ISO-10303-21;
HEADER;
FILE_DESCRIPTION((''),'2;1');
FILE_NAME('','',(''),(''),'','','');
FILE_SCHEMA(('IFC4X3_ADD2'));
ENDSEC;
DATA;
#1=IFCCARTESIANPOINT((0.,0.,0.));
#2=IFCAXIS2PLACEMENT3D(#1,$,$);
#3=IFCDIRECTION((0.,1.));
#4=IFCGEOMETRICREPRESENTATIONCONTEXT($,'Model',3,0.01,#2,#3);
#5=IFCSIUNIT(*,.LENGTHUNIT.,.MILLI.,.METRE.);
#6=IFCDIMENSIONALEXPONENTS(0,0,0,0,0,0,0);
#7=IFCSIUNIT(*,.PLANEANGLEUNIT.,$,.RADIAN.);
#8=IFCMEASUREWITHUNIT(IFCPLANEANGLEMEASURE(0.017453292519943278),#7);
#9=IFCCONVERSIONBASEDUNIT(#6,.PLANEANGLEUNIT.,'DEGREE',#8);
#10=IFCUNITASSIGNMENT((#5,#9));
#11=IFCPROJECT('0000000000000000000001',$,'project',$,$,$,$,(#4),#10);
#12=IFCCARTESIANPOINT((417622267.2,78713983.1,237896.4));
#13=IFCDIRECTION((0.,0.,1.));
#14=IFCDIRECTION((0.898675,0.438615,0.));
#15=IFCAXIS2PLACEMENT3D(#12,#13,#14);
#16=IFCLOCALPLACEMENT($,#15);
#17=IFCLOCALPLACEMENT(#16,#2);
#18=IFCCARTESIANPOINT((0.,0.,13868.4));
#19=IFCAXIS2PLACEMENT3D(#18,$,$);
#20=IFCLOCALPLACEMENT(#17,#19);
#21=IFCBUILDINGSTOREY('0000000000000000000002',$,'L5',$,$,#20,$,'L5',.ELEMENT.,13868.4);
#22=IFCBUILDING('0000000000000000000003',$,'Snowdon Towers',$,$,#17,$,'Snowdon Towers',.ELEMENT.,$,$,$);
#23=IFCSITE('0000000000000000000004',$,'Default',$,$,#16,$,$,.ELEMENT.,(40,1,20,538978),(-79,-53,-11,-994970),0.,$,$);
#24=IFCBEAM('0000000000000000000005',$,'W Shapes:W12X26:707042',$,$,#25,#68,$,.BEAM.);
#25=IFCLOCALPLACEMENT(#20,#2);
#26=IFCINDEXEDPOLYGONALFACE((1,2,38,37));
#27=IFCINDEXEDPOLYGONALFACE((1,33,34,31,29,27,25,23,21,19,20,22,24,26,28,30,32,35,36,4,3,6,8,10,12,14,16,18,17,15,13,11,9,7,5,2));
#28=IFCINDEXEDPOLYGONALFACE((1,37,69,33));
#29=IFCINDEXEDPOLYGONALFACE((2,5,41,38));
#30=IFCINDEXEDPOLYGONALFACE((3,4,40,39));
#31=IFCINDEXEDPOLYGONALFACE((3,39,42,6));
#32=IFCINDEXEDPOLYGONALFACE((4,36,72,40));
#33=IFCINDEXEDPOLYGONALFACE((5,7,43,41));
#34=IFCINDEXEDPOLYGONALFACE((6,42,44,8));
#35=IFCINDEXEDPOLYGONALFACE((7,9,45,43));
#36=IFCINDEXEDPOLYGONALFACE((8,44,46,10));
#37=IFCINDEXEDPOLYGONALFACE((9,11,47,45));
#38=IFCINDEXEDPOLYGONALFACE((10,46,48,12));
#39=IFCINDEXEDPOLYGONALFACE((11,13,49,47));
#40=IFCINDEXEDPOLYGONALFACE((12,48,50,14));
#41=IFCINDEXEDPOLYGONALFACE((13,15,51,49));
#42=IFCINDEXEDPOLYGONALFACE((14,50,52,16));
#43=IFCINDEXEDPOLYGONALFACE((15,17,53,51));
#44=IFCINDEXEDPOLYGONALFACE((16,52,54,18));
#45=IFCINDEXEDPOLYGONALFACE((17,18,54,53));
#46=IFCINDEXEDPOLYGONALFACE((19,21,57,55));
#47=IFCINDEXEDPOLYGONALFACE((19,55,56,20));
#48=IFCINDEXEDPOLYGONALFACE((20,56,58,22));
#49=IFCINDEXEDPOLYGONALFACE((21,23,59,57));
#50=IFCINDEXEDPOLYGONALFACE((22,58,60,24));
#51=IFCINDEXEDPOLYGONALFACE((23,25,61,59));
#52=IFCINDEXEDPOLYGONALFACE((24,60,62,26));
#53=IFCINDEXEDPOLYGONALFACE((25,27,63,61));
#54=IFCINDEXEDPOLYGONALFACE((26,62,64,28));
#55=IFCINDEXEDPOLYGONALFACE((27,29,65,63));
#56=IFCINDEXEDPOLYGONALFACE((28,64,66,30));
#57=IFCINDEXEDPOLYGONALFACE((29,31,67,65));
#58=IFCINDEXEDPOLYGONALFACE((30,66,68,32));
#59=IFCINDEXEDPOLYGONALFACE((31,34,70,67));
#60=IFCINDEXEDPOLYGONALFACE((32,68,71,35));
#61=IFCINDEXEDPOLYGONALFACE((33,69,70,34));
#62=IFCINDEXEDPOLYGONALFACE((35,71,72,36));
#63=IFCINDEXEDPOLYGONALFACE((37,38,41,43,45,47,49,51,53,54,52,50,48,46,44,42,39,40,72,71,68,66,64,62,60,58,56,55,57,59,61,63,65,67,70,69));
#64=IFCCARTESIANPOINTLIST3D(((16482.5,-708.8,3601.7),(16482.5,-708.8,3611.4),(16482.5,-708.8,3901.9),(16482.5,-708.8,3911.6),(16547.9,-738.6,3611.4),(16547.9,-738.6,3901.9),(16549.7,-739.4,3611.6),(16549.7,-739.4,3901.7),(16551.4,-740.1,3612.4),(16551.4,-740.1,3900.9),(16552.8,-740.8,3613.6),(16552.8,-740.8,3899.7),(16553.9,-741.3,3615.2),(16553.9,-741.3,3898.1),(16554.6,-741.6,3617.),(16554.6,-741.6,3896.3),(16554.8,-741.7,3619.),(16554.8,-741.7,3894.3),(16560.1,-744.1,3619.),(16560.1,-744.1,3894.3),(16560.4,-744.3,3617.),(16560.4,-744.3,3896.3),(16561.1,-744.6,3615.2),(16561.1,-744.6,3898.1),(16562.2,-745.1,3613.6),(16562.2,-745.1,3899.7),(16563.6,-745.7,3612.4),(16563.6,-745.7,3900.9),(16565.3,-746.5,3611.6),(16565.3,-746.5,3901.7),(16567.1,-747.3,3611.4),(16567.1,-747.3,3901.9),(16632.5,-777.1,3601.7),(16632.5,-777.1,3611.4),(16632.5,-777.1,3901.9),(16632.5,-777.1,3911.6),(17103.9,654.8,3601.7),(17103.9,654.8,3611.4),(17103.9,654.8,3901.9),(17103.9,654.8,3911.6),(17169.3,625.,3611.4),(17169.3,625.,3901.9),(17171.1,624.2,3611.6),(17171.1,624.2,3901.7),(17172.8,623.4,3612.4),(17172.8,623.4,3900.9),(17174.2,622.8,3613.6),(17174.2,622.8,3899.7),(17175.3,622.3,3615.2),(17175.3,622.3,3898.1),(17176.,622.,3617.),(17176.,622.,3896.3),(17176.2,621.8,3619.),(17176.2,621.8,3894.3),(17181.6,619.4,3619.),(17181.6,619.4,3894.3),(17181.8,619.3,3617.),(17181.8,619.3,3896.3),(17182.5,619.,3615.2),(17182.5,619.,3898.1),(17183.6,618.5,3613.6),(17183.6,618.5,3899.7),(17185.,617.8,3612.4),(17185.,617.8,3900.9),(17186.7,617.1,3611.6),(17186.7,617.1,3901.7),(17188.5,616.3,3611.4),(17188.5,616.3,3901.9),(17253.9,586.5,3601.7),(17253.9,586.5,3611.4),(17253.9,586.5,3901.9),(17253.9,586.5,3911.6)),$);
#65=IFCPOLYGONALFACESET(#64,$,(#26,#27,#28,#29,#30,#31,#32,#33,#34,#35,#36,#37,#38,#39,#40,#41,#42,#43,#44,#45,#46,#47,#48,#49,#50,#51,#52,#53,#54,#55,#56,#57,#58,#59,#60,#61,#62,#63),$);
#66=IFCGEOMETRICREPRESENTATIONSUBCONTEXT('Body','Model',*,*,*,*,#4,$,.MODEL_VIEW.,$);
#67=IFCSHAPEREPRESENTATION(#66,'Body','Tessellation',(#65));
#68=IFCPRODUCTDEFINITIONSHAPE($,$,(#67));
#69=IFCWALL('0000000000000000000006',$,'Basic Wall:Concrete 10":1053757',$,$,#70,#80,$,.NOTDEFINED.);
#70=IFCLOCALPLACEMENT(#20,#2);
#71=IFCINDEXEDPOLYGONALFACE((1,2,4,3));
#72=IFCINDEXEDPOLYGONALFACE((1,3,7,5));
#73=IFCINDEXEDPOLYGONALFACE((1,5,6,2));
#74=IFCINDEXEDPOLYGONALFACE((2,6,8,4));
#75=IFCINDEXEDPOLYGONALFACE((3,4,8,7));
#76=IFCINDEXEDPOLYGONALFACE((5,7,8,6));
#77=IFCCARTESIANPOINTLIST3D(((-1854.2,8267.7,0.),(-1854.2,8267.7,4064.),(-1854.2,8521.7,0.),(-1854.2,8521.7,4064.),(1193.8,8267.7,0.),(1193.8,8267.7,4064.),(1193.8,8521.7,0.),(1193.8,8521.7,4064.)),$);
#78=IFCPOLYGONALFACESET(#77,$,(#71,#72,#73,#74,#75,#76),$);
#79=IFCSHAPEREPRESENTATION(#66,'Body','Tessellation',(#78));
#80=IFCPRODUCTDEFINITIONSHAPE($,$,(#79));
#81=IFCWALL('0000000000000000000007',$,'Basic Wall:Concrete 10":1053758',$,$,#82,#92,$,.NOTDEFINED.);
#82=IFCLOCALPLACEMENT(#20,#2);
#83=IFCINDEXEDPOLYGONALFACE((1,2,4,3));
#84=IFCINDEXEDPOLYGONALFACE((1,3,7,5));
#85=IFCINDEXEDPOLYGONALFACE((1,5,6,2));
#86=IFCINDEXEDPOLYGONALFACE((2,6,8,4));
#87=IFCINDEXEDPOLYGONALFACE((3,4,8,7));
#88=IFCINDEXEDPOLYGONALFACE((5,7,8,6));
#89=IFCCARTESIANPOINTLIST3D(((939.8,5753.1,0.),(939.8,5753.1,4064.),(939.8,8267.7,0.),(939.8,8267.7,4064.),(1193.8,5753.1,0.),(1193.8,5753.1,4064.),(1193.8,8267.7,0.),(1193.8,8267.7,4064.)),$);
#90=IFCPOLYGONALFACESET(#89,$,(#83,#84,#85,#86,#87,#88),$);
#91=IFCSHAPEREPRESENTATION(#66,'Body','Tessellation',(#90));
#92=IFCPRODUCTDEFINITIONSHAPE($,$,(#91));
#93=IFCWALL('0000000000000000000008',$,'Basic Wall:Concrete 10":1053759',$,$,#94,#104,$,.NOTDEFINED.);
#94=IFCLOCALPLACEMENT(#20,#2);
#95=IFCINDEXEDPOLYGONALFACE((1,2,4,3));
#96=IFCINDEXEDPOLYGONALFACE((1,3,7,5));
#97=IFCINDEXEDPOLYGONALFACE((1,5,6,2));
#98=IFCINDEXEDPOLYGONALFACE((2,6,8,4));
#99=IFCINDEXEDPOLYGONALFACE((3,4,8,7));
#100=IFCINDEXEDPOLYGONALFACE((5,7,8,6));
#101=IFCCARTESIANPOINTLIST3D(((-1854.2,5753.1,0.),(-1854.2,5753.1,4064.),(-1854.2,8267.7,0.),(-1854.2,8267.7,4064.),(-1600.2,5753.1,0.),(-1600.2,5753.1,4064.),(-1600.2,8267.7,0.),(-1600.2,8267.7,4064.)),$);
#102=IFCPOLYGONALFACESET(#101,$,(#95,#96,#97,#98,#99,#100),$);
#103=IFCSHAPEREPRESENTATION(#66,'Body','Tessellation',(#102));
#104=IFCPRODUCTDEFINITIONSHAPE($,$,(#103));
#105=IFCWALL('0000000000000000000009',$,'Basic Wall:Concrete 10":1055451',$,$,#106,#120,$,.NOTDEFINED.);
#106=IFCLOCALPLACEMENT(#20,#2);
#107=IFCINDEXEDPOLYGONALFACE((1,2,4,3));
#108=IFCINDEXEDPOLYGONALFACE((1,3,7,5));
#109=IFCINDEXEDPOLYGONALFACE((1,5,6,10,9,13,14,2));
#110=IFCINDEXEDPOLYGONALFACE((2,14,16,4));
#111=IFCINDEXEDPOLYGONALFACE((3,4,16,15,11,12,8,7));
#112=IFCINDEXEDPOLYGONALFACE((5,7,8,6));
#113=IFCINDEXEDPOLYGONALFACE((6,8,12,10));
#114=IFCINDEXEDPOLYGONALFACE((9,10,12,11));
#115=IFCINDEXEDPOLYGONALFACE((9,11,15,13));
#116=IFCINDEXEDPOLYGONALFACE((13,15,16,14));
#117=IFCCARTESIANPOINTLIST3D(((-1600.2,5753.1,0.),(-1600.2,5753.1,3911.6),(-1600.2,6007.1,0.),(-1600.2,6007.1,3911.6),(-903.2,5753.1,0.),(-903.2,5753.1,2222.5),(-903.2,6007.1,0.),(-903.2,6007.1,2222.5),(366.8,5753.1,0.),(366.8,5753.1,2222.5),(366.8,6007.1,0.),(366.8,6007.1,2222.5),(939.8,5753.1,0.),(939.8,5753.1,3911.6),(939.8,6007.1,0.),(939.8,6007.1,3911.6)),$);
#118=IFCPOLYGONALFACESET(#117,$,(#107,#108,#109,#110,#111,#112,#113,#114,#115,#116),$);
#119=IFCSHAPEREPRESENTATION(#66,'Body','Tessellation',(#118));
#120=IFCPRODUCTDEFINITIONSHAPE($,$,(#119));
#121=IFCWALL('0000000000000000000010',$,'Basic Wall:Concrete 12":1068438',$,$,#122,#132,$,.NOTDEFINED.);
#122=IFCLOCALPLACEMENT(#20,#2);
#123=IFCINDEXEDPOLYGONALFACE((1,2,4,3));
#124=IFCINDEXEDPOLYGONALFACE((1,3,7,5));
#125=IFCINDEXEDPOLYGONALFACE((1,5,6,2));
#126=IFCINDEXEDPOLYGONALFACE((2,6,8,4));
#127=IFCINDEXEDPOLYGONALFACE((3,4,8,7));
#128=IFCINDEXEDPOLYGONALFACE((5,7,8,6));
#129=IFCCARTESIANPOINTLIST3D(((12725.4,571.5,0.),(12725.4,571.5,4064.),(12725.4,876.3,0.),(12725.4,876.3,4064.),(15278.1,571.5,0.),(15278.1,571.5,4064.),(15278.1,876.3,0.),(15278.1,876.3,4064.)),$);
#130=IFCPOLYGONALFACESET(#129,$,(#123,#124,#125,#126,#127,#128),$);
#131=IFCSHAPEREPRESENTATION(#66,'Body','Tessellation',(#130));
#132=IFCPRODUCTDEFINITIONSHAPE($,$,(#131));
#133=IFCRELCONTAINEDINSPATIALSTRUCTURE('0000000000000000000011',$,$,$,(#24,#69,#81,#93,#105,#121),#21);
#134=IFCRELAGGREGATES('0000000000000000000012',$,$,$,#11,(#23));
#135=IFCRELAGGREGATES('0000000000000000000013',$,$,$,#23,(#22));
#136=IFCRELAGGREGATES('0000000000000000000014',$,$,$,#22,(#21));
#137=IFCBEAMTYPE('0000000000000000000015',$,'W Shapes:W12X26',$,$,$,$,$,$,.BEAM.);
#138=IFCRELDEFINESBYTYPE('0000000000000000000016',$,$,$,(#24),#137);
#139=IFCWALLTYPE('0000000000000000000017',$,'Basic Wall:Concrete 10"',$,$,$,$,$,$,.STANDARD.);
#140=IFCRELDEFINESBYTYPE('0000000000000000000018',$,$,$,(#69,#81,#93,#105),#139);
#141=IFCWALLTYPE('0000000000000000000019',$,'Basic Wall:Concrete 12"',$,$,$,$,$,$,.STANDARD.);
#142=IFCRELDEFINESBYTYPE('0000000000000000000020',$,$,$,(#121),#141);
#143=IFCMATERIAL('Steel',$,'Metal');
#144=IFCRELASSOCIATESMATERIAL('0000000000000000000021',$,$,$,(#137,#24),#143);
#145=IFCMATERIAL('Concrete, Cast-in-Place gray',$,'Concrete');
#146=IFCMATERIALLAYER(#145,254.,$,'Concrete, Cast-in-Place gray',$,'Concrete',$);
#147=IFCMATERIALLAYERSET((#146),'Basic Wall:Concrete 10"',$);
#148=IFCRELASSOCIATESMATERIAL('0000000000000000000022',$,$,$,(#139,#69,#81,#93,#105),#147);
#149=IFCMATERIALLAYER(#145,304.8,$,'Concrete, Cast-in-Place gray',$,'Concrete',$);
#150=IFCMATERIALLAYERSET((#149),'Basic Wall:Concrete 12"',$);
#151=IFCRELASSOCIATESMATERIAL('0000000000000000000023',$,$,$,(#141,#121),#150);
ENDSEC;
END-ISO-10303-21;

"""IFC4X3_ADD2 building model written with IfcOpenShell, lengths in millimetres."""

from ifc_helpers import new_model, entity, si_unit, converted_unit, direction, frame, frame_2d, origin, place, context, subcontext, project, spatial, polyline, circle_curve, parameter, trimmed, segment, composite_curve, rectangle, outline, extrude, source, transform, mapped, material, layer, layer_set, material_profile, profile_set, profile_usage, type_object, type_shapes, element, save


model = new_model("IFC4X3_ADD2")

# Units and contexts
model_context = context("Model", 3, precision=0.01, world=origin(), true_north=direction((0.0, 1.0)))
body_context = subcontext(model_context, "Body", "Model", "MODEL_VIEW")
ifc_project = project(units=[si_unit("LENGTHUNIT", "METRE", prefix="MILLI"), converted_unit("PLANEANGLEUNIT", "DEGREE", entity("IfcPlaneAngleMeasure", 0.017453292519943278), si_unit("PLANEANGLEUNIT", "RADIAN"), dimensions=[0, 0, 0, 0, 0, 0, 0])], contexts=[model_context])

# Site, building, storey
site_placement = place(None, frame((417622267.2, 78713983.1, 237896.4), z_axis=(0.0, 0.0, 1.0), x_axis=(0.898675, 0.438615, 0.0)))
site = spatial("IfcSite", under=ifc_project, at=site_placement, Name="Default", CompositionType="ELEMENT", RefLatitude=(40, 1, 20, 538978), RefLongitude=(-79, -53, -11, -994970), RefElevation=0.0)
building_placement = place(site_placement, origin())
building = spatial("IfcBuilding", under=site, at=building_placement, Name="Snowdon Towers", LongName="Snowdon Towers", CompositionType="ELEMENT")
storey_placement = place(building_placement, frame((0.0, 0.0, 13868.4)))
storey = spatial("IfcBuildingStorey", under=building, at=storey_placement, Name="L5", LongName="L5", CompositionType="ELEMENT", Elevation=13868.4)

# Shared definitions
ifc_material_1 = material(Name="Steel", Category="Metal")

# Beam
ifc_material_profile_1 = material_profile(ifc_material_1, outline(composite_curve([segment(polyline([(-82.4, -145.3), (-82.4, -154.9)]), True, "CONTINUOUS"), segment(polyline([(-82.4, -154.9), (82.4, -154.9)]), True, "CONTINUOUS"), segment(polyline([(82.4, -154.9), (82.4, -145.3)]), True, "CONTINUOUS"), segment(polyline([(82.4, -145.3), (10.5, -145.3)]), True, "CONTINUOUS"), segment(trimmed(circle_curve(frame_2d((10.5, -137.7), x_axis=(1.0, 0.0)), 7.6), [parameter(180.0)], [parameter(270.0)], True, "PARAMETER"), False, "CONTINUOUS"), segment(polyline([(2.9, -137.7), (2.9, 137.7)]), True, "CONTINUOUS"), segment(trimmed(circle_curve(frame_2d((10.5, 137.7), x_axis=(1.0, 0.0)), 7.6), [parameter(90.0)], [parameter(180.0)], True, "PARAMETER"), False, "CONTINUOUS"), segment(polyline([(10.5, 145.3), (82.4, 145.3)]), True, "CONTINUOUS"), segment(polyline([(82.4, 145.3), (82.4, 154.9)]), True, "CONTINUOUS"), segment(polyline([(82.4, 154.9), (-82.4, 154.9)]), True, "CONTINUOUS"), segment(polyline([(-82.4, 154.9), (-82.4, 145.3)]), True, "CONTINUOUS"), segment(polyline([(-82.4, 145.3), (-10.5, 145.3)]), True, "CONTINUOUS"), segment(trimmed(circle_curve(frame_2d((-10.5, 137.7), x_axis=(1.0, 0.0)), 7.6), [parameter(360.0)], [parameter(90.0)], True, "PARAMETER"), False, "CONTINUOUS"), segment(polyline([(-2.9, 137.7), (-2.9, -137.7)]), True, "CONTINUOUS"), segment(trimmed(circle_curve(frame_2d((-10.5, -137.7), x_axis=(1.0, 0.0)), 7.6), [parameter(270.0)], [parameter(360.0)], True, "PARAMETER"), False, "CONTINUOUS"), segment(polyline([(-10.5, -145.3), (-82.4, -145.3)]), True, "CONTINUOUS")], self_intersect=False)), Name="W12X26")
ifc_profile_set_1 = profile_set([ifc_material_profile_1], Name="W12X26")
ifc_profile_usage_1 = profile_usage(ifc_profile_set_1, cardinal=8)
beam_type_1 = type_object("IfcBeamType", Name="W Shapes:W12X26", PredefinedType="BEAM", material=ifc_profile_set_1)
shared_shape_1 = source(origin(), body_context, "Body", "SweptSolid", [
    extrude(outline(composite_curve([segment(polyline([(-82.4, -145.3), (-82.4, -154.9)]), True, "CONTINUOUS"), segment(polyline([(-82.4, -154.9), (82.4, -154.9)]), True, "CONTINUOUS"), segment(polyline([(82.4, -154.9), (82.4, -145.3)]), True, "CONTINUOUS"), segment(polyline([(82.4, -145.3), (10.5, -145.3)]), True, "CONTINUOUS"), segment(trimmed(circle_curve(frame_2d((10.5, -137.7), x_axis=(0.0, -1.0)), 7.6), [parameter(270.0)], [parameter(360.0)], True, "PARAMETER"), False, "CONTINUOUS"), segment(polyline([(2.9, -137.7), (2.9, 137.7)]), True, "CONTINUOUS"), segment(trimmed(circle_curve(frame_2d((10.5, 137.7), x_axis=(-1.0, 0.0)), 7.6), [parameter(270.0)], [parameter(360.0)], True, "PARAMETER"), False, "CONTINUOUS"), segment(polyline([(10.5, 145.3), (82.4, 145.3)]), True, "CONTINUOUS"), segment(polyline([(82.4, 145.3), (82.4, 154.9)]), True, "CONTINUOUS"), segment(polyline([(82.4, 154.9), (-82.4, 154.9)]), True, "CONTINUOUS"), segment(polyline([(-82.4, 154.9), (-82.4, 145.3)]), True, "CONTINUOUS"), segment(polyline([(-82.4, 145.3), (-10.5, 145.3)]), True, "CONTINUOUS"), segment(trimmed(circle_curve(frame_2d((-10.5, 137.7), x_axis=(0.0, 1.0)), 7.6), [parameter(270.0)], [parameter(0.0)], True, "PARAMETER"), False, "CONTINUOUS"), segment(polyline([(-2.9, 137.7), (-2.9, -137.7)]), True, "CONTINUOUS"), segment(trimmed(circle_curve(frame_2d((-10.5, -137.7), x_axis=(1.0, 0.0)), 7.6), [parameter(270.0)], [parameter(0.0)], True, "PARAMETER"), False, "CONTINUOUS"), segment(polyline([(-10.5, -145.3), (-82.4, -145.3)]), True, "CONTINUOUS")], self_intersect=False)), frame((-779.4, 0.0, 0.0), z_axis=(-1.0, 0.0, 0.0), x_axis=(0.0, -1.0, 0.0)), (0.0, 0.0, -1.0), 1498.5),
])
type_shapes(beam_type_1, [shared_shape_1])
beam_1_placement = place(storey_placement, frame((16880.7, -33.7, 3756.7), z_axis=(0.0, 0.0, 1.0), x_axis=(0.414693, 0.909961, 0.0)))
element("IfcBeam", 1, at=beam_1_placement, inside=storey, type_object=beam_type_1, material=ifc_profile_usage_1, Name="W Shapes:W12X26:707042", PredefinedType="BEAM", context=body_context, shape_type="MappedRepresentation", body=[
    mapped(shared_shape_1, transform((0.0, 0.0, 0.0), scale=1.0)),
])

# Walls
ifc_material_2 = material(Name="Concrete, Cast-in-Place gray", Category="Concrete")
ifc_layer_1 = layer(ifc_material_2, 254.0, Name="Concrete, Cast-in-Place gray", Category="Concrete")
ifc_layer_set_1 = layer_set([ifc_layer_1], Name="Basic Wall:Concrete 10\"")
wall_type_1 = type_object("IfcWallType", Name="Basic Wall:Concrete 10\"", PredefinedType="STANDARD", material=ifc_layer_set_1)
wall_1_placement = place(storey_placement, frame((-1854.2, 8394.7, 0.0)))
element("IfcWall", 2, at=wall_1_placement, inside=storey, type_object=wall_type_1, material=ifc_layer_set_1, Name="Basic Wall:Concrete 10\":1053757", PredefinedType="NOTDEFINED", context=body_context, shape_type="SweptSolid", body=[
    extrude(rectangle(XDim=3048.0, YDim=254.0, at=frame_2d((1524.0, 0.0), x_axis=(-1.0, 0.0))), origin(), (0.0, 0.0, 1.0), 4064.0),
])
wall_2_placement = place(storey_placement, frame((1066.8, 8267.7, 0.0), z_axis=(0.0, 0.0, 1.0), x_axis=(0.0, -1.0, 0.0)))
element("IfcWall", 3, at=wall_2_placement, inside=storey, type_object=wall_type_1, material=ifc_layer_set_1, Name="Basic Wall:Concrete 10\":1053758", PredefinedType="NOTDEFINED", context=body_context, shape_type="SweptSolid", body=[
    extrude(rectangle(XDim=2514.6, YDim=254.0, at=frame_2d((1257.3, 0.0), x_axis=(-1.0, 0.0))), origin(), (0.0, 0.0, 1.0), 4064.0),
])
wall_3_placement = place(storey_placement, frame((-1727.2, 5753.1, 0.0), z_axis=(0.0, 0.0, 1.0), x_axis=(0.0, 1.0, 0.0)))
element("IfcWall", 4, at=wall_3_placement, inside=storey, type_object=wall_type_1, material=ifc_layer_set_1, Name="Basic Wall:Concrete 10\":1053759", PredefinedType="NOTDEFINED", context=body_context, shape_type="SweptSolid", body=[
    extrude(rectangle(XDim=2514.6, YDim=254.0, at=frame_2d((1257.3, 0.0), x_axis=(-1.0, 0.0))), origin(), (0.0, 0.0, 1.0), 4064.0),
])

# Wall, opening
wall_4_placement = place(storey_placement, frame((939.8, 5880.1, 0.0), z_axis=(0.0, 0.0, 1.0), x_axis=(-1.0, 0.0, 0.0)))
wall_4 = element("IfcWall", 5, at=wall_4_placement, inside=storey, type_object=wall_type_1, material=ifc_layer_set_1, Name="Basic Wall:Concrete 10\":1055451", PredefinedType="NOTDEFINED", context=body_context, shape_type="SweptSolid", body=[
    extrude(rectangle(XDim=2540.0, YDim=254.0, at=frame_2d((1270.0, 0.0), x_axis=(-1.0, 0.0))), origin(), (0.0, 0.0, 1.0), 3911.6),
])
opening_placement = place(wall_4_placement, origin())
element("IfcOpeningElement", 6, at=opening_placement, cuts=wall_4, PredefinedType="OPENING", context=body_context, shape_type="SweptSolid", body=[
    extrude(rectangle(XDim=2222.5, YDim=1270.0, at=frame_2d((0.0, 0.0), x_axis=(0.0, 1.0))), frame((1208.0, 127.0, 1111.2), z_axis=(0.0, -1.0, 0.0), x_axis=(1.0, 0.0, 0.0)), (0.0, 0.0, 1.0), 254.0),
])

# Wall
ifc_layer_2 = layer(ifc_material_2, 304.8, Name="Concrete, Cast-in-Place gray", Category="Concrete")
ifc_layer_set_2 = layer_set([ifc_layer_2], Name="Basic Wall:Concrete 12\"")
wall_type_2 = type_object("IfcWallType", Name="Basic Wall:Concrete 12\"", PredefinedType="STANDARD", material=ifc_layer_set_2)
wall_5_placement = place(storey_placement, frame((15278.1, 723.9, 0.0), z_axis=(0.0, 0.0, 1.0), x_axis=(-1.0, 0.0, 0.0)))
element("IfcWall", 7, at=wall_5_placement, inside=storey, type_object=wall_type_2, material=ifc_layer_set_2, Name="Basic Wall:Concrete 12\":1068438", PredefinedType="NOTDEFINED", context=body_context, shape_type="SweptSolid", body=[
    extrude(rectangle(XDim=2552.7, YDim=304.8, at=frame_2d((1276.3, 0.0), x_axis=(-1.0, 0.0))), origin(), (0.0, 0.0, 1.0), 4064.0),
])

save(model, "model.ifc")
